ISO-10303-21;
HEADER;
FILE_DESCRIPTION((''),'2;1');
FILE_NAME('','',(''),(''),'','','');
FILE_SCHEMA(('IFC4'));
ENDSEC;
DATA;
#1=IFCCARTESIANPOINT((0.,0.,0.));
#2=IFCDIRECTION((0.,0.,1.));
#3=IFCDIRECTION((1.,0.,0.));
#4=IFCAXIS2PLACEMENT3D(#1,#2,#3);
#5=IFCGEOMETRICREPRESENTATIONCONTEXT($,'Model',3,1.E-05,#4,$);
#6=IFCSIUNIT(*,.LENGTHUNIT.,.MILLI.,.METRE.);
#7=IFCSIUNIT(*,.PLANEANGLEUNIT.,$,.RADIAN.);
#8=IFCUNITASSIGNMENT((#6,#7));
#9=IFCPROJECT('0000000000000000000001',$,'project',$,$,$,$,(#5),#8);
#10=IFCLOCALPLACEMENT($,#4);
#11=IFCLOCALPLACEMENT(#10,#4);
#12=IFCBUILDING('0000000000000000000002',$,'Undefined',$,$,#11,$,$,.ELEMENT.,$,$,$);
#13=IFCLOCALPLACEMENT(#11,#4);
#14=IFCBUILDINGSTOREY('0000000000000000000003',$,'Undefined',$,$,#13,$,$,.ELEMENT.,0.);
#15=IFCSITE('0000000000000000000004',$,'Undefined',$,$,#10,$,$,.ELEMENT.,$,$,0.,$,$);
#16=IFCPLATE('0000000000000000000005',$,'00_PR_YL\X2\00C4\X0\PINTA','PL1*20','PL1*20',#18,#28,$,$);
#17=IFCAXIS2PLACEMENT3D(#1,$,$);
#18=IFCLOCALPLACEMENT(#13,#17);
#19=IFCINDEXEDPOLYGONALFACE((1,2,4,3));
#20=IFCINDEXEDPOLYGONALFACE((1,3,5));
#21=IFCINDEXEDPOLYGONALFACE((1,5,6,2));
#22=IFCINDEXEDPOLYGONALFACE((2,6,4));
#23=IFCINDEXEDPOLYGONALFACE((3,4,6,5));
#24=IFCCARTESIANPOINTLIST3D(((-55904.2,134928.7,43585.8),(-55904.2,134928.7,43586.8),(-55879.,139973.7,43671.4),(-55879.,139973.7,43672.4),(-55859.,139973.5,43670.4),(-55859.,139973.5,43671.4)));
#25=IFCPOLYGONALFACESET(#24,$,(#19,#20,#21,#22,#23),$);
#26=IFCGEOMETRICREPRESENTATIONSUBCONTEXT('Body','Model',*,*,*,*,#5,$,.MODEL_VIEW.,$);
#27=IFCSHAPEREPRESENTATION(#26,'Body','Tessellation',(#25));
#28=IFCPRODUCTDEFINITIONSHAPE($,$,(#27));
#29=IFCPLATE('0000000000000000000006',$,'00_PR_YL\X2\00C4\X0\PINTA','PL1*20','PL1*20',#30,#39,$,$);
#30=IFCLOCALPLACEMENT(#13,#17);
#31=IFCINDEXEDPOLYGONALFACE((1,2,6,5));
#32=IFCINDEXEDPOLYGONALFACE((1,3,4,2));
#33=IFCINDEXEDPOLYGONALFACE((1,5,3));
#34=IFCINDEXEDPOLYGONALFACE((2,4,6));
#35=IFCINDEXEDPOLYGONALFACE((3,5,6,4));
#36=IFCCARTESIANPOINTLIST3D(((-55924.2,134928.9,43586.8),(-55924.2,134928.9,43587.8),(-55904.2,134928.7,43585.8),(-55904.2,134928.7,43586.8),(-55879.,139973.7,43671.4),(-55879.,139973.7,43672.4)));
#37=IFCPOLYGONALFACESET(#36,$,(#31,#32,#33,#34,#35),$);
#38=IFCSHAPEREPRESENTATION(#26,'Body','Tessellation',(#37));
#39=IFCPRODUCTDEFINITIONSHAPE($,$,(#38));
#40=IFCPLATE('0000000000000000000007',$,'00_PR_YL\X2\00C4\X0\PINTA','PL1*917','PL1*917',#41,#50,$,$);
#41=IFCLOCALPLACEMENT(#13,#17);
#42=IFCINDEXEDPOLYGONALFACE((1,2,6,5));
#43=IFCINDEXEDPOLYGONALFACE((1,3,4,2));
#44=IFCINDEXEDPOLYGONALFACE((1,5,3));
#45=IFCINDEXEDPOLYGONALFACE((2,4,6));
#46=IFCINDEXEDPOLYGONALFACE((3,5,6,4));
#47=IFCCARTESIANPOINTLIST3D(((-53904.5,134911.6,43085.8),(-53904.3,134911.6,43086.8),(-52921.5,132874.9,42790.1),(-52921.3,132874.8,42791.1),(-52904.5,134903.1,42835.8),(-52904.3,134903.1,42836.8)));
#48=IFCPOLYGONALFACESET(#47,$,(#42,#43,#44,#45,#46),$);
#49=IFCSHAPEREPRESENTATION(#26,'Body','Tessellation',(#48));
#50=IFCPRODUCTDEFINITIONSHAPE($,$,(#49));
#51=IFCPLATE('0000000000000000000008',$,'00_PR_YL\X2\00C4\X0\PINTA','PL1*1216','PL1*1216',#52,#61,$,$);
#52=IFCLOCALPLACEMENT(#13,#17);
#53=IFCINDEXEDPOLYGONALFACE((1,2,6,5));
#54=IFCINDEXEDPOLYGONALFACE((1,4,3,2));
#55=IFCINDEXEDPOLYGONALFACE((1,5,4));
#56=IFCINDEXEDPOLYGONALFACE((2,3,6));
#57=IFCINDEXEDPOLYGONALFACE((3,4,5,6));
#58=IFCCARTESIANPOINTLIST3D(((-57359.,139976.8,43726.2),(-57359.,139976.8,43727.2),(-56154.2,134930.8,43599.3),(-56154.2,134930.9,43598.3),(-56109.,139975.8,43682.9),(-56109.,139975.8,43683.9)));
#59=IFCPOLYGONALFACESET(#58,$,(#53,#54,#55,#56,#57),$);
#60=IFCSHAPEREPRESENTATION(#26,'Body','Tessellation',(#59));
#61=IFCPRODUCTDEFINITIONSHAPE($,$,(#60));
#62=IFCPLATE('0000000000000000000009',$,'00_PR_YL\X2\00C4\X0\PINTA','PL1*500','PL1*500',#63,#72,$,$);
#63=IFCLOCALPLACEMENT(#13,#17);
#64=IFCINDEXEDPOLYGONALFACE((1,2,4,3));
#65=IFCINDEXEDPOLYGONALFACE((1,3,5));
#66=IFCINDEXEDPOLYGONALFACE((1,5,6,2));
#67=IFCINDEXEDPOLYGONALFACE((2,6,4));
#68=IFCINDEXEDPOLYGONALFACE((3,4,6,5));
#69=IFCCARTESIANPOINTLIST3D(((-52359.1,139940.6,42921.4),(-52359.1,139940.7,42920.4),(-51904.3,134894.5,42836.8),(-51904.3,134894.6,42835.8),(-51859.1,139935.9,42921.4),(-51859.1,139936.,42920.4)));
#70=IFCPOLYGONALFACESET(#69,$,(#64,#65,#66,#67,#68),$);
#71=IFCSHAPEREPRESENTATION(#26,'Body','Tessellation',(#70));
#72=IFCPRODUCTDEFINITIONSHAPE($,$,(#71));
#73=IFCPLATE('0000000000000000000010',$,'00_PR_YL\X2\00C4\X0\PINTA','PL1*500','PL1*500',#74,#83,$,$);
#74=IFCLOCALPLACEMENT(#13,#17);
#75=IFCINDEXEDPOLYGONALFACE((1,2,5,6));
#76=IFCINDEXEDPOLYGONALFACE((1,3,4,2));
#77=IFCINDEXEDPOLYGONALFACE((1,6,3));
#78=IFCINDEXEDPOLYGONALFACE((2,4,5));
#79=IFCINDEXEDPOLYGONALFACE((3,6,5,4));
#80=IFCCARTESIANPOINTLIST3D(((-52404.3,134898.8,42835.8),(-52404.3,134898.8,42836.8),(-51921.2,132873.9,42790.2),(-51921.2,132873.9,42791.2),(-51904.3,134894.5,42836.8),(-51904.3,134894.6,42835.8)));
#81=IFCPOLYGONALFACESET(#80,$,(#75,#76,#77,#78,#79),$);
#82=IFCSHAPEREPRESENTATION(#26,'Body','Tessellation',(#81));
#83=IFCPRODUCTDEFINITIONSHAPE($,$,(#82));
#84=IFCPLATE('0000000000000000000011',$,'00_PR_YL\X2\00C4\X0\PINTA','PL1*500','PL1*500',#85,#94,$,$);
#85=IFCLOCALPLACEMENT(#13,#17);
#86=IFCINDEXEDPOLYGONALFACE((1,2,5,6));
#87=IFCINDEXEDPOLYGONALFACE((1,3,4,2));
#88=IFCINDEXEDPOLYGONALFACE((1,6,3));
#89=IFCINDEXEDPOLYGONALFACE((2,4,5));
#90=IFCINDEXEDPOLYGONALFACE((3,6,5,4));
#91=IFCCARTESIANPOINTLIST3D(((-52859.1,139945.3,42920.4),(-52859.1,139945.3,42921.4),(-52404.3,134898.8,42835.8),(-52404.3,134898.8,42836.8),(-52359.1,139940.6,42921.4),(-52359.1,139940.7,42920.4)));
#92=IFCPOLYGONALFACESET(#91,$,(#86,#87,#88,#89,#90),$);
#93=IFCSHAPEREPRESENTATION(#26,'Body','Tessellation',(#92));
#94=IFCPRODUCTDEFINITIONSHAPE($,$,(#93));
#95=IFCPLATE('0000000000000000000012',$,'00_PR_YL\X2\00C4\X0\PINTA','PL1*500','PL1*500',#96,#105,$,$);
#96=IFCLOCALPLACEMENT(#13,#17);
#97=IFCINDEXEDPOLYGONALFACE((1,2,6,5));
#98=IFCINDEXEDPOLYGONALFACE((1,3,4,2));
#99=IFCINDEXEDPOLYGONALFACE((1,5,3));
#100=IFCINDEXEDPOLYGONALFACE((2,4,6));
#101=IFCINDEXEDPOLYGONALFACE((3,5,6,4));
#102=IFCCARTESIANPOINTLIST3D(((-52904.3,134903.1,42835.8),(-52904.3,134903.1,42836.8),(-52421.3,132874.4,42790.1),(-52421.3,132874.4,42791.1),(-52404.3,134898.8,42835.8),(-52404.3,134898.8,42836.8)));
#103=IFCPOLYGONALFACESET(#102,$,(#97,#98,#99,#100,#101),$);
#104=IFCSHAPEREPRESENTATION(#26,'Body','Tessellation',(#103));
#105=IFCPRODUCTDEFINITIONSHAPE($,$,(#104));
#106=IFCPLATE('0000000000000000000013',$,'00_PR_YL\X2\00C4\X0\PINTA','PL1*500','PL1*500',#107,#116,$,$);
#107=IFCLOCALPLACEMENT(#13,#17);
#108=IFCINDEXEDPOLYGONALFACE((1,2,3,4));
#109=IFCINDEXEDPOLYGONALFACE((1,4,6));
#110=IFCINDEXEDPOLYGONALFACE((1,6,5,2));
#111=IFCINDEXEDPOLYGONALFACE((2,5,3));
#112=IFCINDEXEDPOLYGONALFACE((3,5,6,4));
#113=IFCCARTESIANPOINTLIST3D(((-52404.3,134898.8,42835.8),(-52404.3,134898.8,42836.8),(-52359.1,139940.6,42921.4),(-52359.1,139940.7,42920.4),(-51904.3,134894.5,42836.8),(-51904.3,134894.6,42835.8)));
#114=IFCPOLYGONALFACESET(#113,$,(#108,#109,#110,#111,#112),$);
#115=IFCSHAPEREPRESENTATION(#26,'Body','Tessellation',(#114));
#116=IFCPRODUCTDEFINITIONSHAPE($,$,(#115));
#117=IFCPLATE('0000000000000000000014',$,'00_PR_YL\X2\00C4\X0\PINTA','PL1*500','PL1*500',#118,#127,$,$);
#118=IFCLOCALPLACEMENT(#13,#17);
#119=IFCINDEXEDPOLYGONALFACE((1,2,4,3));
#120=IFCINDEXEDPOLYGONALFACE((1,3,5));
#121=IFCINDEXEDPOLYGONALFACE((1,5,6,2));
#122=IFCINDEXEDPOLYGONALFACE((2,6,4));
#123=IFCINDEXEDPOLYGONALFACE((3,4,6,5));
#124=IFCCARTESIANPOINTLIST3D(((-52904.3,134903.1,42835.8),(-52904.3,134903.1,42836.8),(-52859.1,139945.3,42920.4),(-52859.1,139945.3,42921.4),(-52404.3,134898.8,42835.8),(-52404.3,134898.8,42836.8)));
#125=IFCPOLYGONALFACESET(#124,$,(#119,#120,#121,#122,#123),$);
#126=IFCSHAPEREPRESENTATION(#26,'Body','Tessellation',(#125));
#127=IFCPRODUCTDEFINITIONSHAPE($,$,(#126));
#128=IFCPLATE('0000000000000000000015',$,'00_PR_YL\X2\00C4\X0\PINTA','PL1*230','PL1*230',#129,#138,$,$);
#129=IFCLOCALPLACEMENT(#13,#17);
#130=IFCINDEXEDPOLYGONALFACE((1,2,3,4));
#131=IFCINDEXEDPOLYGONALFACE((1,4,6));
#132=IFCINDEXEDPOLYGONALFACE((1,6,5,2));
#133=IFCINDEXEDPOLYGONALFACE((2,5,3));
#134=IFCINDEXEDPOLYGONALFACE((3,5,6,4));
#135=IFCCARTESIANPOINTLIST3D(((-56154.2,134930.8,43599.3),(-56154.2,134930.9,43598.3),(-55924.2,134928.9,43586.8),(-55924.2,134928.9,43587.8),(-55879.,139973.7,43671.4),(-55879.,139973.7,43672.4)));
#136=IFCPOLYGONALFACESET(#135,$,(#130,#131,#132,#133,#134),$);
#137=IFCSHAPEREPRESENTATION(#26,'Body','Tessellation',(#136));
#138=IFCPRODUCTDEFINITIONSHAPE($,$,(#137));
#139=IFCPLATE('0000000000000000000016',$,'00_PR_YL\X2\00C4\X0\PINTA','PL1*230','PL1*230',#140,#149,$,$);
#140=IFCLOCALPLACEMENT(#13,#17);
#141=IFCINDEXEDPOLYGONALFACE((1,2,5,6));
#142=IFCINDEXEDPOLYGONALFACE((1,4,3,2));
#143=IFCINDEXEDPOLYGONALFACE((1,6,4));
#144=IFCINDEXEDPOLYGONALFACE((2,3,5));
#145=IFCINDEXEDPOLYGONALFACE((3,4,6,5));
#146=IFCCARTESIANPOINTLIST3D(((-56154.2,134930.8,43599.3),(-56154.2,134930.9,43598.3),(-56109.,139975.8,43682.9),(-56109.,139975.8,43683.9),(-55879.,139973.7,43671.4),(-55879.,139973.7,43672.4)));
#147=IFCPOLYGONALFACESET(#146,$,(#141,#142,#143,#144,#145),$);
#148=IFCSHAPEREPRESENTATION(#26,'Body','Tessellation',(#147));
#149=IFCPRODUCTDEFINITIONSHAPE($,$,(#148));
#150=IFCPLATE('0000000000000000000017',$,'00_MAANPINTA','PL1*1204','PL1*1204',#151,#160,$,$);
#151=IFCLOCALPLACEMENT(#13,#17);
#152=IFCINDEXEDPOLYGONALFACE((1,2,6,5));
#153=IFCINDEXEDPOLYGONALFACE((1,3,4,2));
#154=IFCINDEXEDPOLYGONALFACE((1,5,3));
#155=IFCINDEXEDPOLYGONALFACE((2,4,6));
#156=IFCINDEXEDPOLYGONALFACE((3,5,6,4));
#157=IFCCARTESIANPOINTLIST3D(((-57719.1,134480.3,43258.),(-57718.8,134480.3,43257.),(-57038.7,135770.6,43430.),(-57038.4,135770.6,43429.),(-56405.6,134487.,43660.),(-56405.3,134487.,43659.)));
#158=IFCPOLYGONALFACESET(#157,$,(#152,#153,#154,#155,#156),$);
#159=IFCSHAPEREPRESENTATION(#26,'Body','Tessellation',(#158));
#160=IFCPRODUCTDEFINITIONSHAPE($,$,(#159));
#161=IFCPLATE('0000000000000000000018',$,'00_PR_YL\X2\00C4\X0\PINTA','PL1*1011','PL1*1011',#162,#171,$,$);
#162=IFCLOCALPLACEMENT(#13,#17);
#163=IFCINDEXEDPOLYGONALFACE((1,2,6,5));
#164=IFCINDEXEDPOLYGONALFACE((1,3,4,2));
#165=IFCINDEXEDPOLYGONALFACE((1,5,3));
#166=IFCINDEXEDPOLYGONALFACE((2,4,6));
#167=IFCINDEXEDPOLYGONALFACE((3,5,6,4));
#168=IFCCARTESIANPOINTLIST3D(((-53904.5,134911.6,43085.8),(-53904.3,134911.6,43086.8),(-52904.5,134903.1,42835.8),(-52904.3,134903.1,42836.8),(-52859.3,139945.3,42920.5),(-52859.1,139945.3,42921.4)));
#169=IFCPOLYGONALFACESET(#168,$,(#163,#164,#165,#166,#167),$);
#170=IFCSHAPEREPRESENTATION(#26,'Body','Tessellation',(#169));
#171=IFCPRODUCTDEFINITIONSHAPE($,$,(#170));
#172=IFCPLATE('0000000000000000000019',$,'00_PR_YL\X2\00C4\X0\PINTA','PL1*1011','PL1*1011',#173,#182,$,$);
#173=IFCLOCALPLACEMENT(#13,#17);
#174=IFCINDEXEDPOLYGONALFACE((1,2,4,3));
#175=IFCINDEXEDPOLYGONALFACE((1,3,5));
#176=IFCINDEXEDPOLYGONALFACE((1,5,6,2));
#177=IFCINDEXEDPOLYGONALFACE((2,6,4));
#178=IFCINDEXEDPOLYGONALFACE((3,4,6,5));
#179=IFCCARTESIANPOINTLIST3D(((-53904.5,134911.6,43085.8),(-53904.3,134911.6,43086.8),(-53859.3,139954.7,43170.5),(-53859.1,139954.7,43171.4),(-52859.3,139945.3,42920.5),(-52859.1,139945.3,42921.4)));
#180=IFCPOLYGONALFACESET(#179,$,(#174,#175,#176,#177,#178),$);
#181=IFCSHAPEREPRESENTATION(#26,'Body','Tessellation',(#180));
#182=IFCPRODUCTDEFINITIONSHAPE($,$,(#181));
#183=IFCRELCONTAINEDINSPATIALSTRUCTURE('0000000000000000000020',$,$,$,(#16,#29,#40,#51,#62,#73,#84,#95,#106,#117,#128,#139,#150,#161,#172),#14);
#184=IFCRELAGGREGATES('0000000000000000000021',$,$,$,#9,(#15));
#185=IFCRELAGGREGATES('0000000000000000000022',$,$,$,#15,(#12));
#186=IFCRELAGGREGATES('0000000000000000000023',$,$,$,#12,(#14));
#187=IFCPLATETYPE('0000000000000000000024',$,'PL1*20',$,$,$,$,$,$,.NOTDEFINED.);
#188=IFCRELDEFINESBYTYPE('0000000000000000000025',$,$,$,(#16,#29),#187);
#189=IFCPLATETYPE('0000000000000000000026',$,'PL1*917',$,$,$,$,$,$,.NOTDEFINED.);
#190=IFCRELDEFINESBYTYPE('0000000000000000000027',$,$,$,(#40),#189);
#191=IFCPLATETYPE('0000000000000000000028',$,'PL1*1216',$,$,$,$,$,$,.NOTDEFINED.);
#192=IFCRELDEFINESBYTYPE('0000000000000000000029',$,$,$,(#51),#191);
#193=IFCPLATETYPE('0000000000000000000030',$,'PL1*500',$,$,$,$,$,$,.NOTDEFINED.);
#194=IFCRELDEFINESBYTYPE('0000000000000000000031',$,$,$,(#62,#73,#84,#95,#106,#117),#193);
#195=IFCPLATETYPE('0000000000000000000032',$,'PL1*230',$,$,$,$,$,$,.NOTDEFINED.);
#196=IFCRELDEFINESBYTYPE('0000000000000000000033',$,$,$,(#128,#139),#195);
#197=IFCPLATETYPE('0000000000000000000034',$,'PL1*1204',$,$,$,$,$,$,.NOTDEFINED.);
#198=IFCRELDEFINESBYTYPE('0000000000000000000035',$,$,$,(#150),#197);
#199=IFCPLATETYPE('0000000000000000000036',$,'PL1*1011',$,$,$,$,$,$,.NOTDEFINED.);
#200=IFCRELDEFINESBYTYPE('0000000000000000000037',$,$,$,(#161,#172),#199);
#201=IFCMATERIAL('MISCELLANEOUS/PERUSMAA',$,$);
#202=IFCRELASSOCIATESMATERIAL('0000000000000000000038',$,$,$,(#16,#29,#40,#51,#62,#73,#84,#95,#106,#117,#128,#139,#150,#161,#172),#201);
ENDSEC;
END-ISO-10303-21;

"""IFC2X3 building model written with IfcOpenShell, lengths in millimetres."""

from ifc_helpers import new_model, si_unit, frame, origin_with_axes, place, context, subcontext, project, spatial, polyline, outline, extrude, material, type_object, element, save


model = new_model("IFC2X3")

# Units and contexts
model_context = context("Model", 3, precision=1e-05, world=origin_with_axes())
body_context = subcontext(model_context, "Body", "Model", "MODEL_VIEW")
ifc_project = project(units=[si_unit("LENGTHUNIT", "METRE", prefix="MILLI"), si_unit("PLANEANGLEUNIT", "RADIAN")], contexts=[model_context])

# Site, building, storey
site_placement = place(None, origin_with_axes())
site = spatial("IfcSite", under=ifc_project, at=site_placement, Name="Undefined", CompositionType="ELEMENT", RefElevation=0.0)
building_placement = place(site_placement, origin_with_axes())
building = spatial("IfcBuilding", under=site, at=building_placement, Name="Undefined", CompositionType="ELEMENT")
storey_placement = place(building_placement, origin_with_axes())
storey = spatial("IfcBuildingStorey", under=building, at=storey_placement, Name="Undefined", CompositionType="ELEMENT", Elevation=0.0)

# Plates
ifc_material = material(Name="MISCELLANEOUS/PERUSMAA")
plate_type_1 = type_object("IfcPlateType", Name="PL1*20", PredefinedType="NOTDEFINED")
plate_1_placement = place(storey_placement, frame((-55904.2, 134928.7, 43586.3), z_axis=(-0.049773, 0.017208, -0.998612), x_axis=(0.004996, 0.999843, 0.01698)))
element("IfcPlate", 1, at=plate_1_placement, inside=storey, type_object=plate_type_1, material=ifc_material, Name="00_PR_YLÄPINTA", Description="PL1*20", ObjectType="PL1*20", context=body_context, shape_type="SweptSolid", body=[
    extrude(outline(polyline([(0.0, 0.0), (5045.8, 0.0), (5045.6, 20.0), (0.0, 0.0)])), frame((0.0, 0.0, -0.5), z_axis=(0.0, 0.0, 1.0), x_axis=(1.0, 0.0, 0.0)), (0.0, 0.0, 1.0), 1.0),
])
plate_2_placement = place(storey_placement, frame((-55924.2, 134928.9, 43587.3), z_axis=(-0.049785, 0.017208, -0.998612), x_axis=(0.00896, 0.999819, 0.016782)))
element("IfcPlate", 2, at=plate_2_placement, inside=storey, type_object=plate_type_1, material=ifc_material, Name="00_PR_YLÄPINTA", Description="PL1*20", ObjectType="PL1*20", context=body_context, shape_type="SweptSolid", body=[
    extrude(outline(polyline([(0.0, 0.0), (5045.7, 0.0), (0.0, 20.0), (0.0, 0.0)])), frame((0.0, 0.0, -0.5), z_axis=(0.0, 0.0, 1.0), x_axis=(1.0, 0.0, 0.0)), (0.0, 0.0, 1.0), 1.0),
])
plate_type_2 = type_object("IfcPlateType", Name="PL1*917", PredefinedType="NOTDEFINED")
plate_3_placement = place(storey_placement, frame((-52904.4, 134903.1, 42836.3), z_axis=(-0.242283, 0.023882, -0.969912), x_axis=(-0.008367, -0.999711, -0.022526)))
element("IfcPlate", 3, at=plate_3_placement, inside=storey, type_object=plate_type_2, material=ifc_material, Name="00_PR_YLÄPINTA", Description="PL1*917", ObjectType="PL1*917", context=body_context, shape_type="SweptSolid", body=[
    extrude(outline(polyline([(0.0, 0.0), (2028.8, 0.0), (-5.8, 1030.8), (0.0, 0.0)])), frame((0.0, 0.0, -0.5), z_axis=(0.0, 0.0, 1.0), x_axis=(1.0, 0.0, 0.0)), (0.0, 0.0, 1.0), 1.0),
])
plate_type_3 = type_object("IfcPlateType", Name="PL1*1216", PredefinedType="NOTDEFINED")
plate_4_placement = place(storey_placement, frame((-56109.0, 139975.8, 43683.4), z_axis=(-0.034582, 0.017082, -0.999256), x_axis=(-0.00896, -0.999819, -0.016782)))
element("IfcPlate", 4, at=plate_4_placement, inside=storey, type_object=plate_type_3, material=ifc_material, Name="00_PR_YLÄPINTA", Description="PL1*1216", ObjectType="PL1*1216", context=body_context, shape_type="SweptSolid", body=[
    extrude(outline(polyline([(0.0, 0.0), (5045.9, 0.0), (9.5, 1250.8), (0.0, 0.0)])), frame((0.0, 0.0, -0.5), z_axis=(0.0, 0.0, 1.0), x_axis=(1.0, 0.0, 0.0)), (0.0, 0.0, 1.0), 1.0),
])
plate_type_4 = type_object("IfcPlateType", Name="PL1*500", PredefinedType="NOTDEFINED")
plate_5_placement = place(storey_placement, frame((-51859.1, 139936.0, 42920.9), z_axis=(0.000158, 0.016793, -0.999859), x_axis=(-0.00896, -0.999819, -0.016793)))
element("IfcPlate", 5, at=plate_5_placement, inside=storey, type_object=plate_type_4, material=ifc_material, Name="00_PR_YLÄPINTA", Description="PL1*500", ObjectType="PL1*500", context=body_context, shape_type="SweptSolid", body=[
    extrude(outline(polyline([(0.0, 0.0), (5042.3, 0.0), (-0.2, 500.0), (0.0, 0.0)])), frame((0.0, 0.0, -0.5), z_axis=(0.0, 0.0, 1.0), x_axis=(1.0, 0.0, 0.0)), (0.0, 0.0, 1.0), 1.0),
])
plate_6_placement = place(storey_placement, frame((-51904.3, 134894.6, 42836.3), z_axis=(0.000192, 0.022529, -0.999746), x_axis=(-0.008368, -0.999711, -0.02253)))
element("IfcPlate", 6, at=plate_6_placement, inside=storey, type_object=plate_type_4, material=ifc_material, Name="00_PR_YLÄPINTA", Description="PL1*500", ObjectType="PL1*500", context=body_context, shape_type="SweptSolid", body=[
    extrude(outline(polyline([(0.0, 0.0), (2021.2, 0.0), (-0.1, 500.0), (0.0, 0.0)])), frame((0.0, 0.0, -0.5), z_axis=(0.0, 0.0, 1.0), x_axis=(1.0, 0.0, 0.0)), (0.0, 0.0, 1.0), 1.0),
])
plate_7_placement = place(storey_placement, frame((-52359.1, 139940.6, 42920.9), z_axis=(0.000158, 0.016791, -0.999859), x_axis=(-0.00896, -0.999819, -0.016792)))
element("IfcPlate", 7, at=plate_7_placement, inside=storey, type_object=plate_type_4, material=ifc_material, Name="00_PR_YLÄPINTA", Description="PL1*500", ObjectType="PL1*500", context=body_context, shape_type="SweptSolid", body=[
    extrude(outline(polyline([(0.0, 0.0), (5042.7, 0.0), (-0.2, 500.0), (0.0, 0.0)])), frame((0.0, 0.0, -0.5), z_axis=(0.0, 0.0, 1.0), x_axis=(1.0, 0.0, 0.0)), (0.0, 0.0, 1.0), 1.0),
])
plate_8_placement = place(storey_placement, frame((-52404.3, 134898.8, 42836.3), z_axis=(0.000192, 0.022527, -0.999746), x_axis=(-0.008368, -0.999711, -0.022528)))
element("IfcPlate", 8, at=plate_8_placement, inside=storey, type_object=plate_type_4, material=ifc_material, Name="00_PR_YLÄPINTA", Description="PL1*500", ObjectType="PL1*500", context=body_context, shape_type="SweptSolid", body=[
    extrude(outline(polyline([(0.0, 0.0), (2025.0, 0.0), (-0.1, 500.0), (0.0, 0.0)])), frame((0.0, 0.0, -0.5), z_axis=(0.0, 0.0, 1.0), x_axis=(1.0, 0.0, 0.0)), (0.0, 0.0, 1.0), 1.0),
])
plate_9_placement = place(storey_placement, frame((-52404.3, 134898.8, 42836.3), z_axis=(0.000143, 0.016791, -0.999859), x_axis=(0.00896, 0.999819, 0.016792)))
element("IfcPlate", 9, at=plate_9_placement, inside=storey, type_object=plate_type_4, material=ifc_material, Name="00_PR_YLÄPINTA", Description="PL1*500", ObjectType="PL1*500", context=body_context, shape_type="SweptSolid", body=[
    extrude(outline(polyline([(0.0, 0.0), (5042.7, 0.0), (0.2, 500.0), (0.0, 0.0)])), frame((0.0, 0.0, -0.5), z_axis=(0.0, 0.0, 1.0), x_axis=(1.0, 0.0, 0.0)), (0.0, 0.0, 1.0), 1.0),
])
plate_10_placement = place(storey_placement, frame((-52904.3, 134903.1, 42836.3), z_axis=(0.000143, 0.01679, -0.999859), x_axis=(0.00896, 0.999819, 0.01679)))
element("IfcPlate", 10, at=plate_10_placement, inside=storey, type_object=plate_type_4, material=ifc_material, Name="00_PR_YLÄPINTA", Description="PL1*500", ObjectType="PL1*500", context=body_context, shape_type="SweptSolid", body=[
    extrude(outline(polyline([(0.0, 0.0), (5043.2, 0.0), (0.2, 500.0), (0.0, 0.0)])), frame((0.0, 0.0, -0.5), z_axis=(0.0, 0.0, 1.0), x_axis=(1.0, 0.0, 0.0)), (0.0, 0.0, 1.0), 1.0),
])
plate_type_5 = type_object("IfcPlateType", Name="PL1*230", PredefinedType="NOTDEFINED")
plate_11_placement = place(storey_placement, frame((-55879.0, 139973.7, 43671.9), z_axis=(-0.049785, 0.017208, -0.998612), x_axis=(-0.00896, -0.999819, -0.016782)))
element("IfcPlate", 11, at=plate_11_placement, inside=storey, type_object=plate_type_5, material=ifc_material, Name="00_PR_YLÄPINTA", Description="PL1*230", ObjectType="PL1*230", context=body_context, shape_type="SweptSolid", body=[
    extrude(outline(polyline([(0.0, 0.0), (5045.7, 0.0), (5045.6, 230.3), (0.0, 0.0)])), frame((0.0, 0.0, -0.5), z_axis=(0.0, 0.0, 1.0), x_axis=(1.0, 0.0, 0.0)), (0.0, 0.0, 1.0), 1.0),
])
plate_12_placement = place(storey_placement, frame((-56154.2, 134930.8, 43598.8), z_axis=(-0.049771, 0.017207, -0.998612), x_axis=(0.00896, 0.999819, 0.016782)))
element("IfcPlate", 12, at=plate_12_placement, inside=storey, type_object=plate_type_5, material=ifc_material, Name="00_PR_YLÄPINTA", Description="PL1*230", ObjectType="PL1*230", context=body_context, shape_type="SweptSolid", body=[
    extrude(outline(polyline([(0.0, 0.0), (5045.9, 0.0), (5045.6, 230.3), (0.0, 0.0)])), frame((0.0, 0.0, -0.5), z_axis=(0.0, 0.0, 1.0), x_axis=(1.0, 0.0, 0.0)), (0.0, 0.0, 1.0), 1.0),
])
plate_type_6 = type_object("IfcPlateType", Name="PL1*1204", PredefinedType="NOTDEFINED")
plate_13_placement = place(storey_placement, frame((-56405.4, 134487.0, 43659.5), z_axis=(0.292679, -0.026916, -0.955832), x_axis=(-0.956205, -0.004849, -0.292656)))
element("IfcPlate", 13, at=plate_13_placement, inside=storey, type_object=plate_type_6, material=ifc_material, Name="00_MAANPINTA", Description="PL1*1204", ObjectType="PL1*1204", context=body_context, shape_type="SweptSolid", body=[
    extrude(outline(polyline([(0.0, 0.0), (1373.6, 0.0), (666.4, 1287.3), (0.0, 0.0)])), frame((0.0, 0.0, -0.5), z_axis=(0.0, 0.0, 1.0), x_axis=(1.0, 0.0, 0.0)), (0.0, 0.0, 1.0), 1.0),
])
plate_type_7 = type_object("IfcPlateType", Name="PL1*1011", PredefinedType="NOTDEFINED")
plate_14_placement = place(storey_placement, frame((-52859.2, 139945.3, 42921.0), z_axis=(-0.242354, 0.018462, -0.970012), x_axis=(-0.00896, -0.999819, -0.01679)))
element("IfcPlate", 14, at=plate_14_placement, inside=storey, type_object=plate_type_7, material=ifc_material, Name="00_PR_YLÄPINTA", Description="PL1*1011", ObjectType="PL1*1011", context=body_context, shape_type="SweptSolid", body=[
    extrude(outline(polyline([(0.0, 0.0), (5043.2, 0.0), (5039.4, 1030.8), (0.0, 0.0)])), frame((0.0, 0.0, -0.5), z_axis=(0.0, 0.0, 1.0), x_axis=(1.0, 0.0, 0.0)), (0.0, 0.0, 1.0), 1.0),
])
plate_15_placement = place(storey_placement, frame((-53904.4, 134911.6, 43086.3), z_axis=(-0.242341, 0.018459, -0.970015), x_axis=(0.00896, 0.999819, 0.016788)))
element("IfcPlate", 15, at=plate_15_placement, inside=storey, type_object=plate_type_7, material=ifc_material, Name="00_PR_YLÄPINTA", Description="PL1*1011", ObjectType="PL1*1011", context=body_context, shape_type="SweptSolid", body=[
    extrude(outline(polyline([(0.0, 0.0), (5044.0, 0.0), (5039.4, 1030.8), (0.0, 0.0)])), frame((0.0, 0.0, -0.5), z_axis=(0.0, 0.0, 1.0), x_axis=(1.0, 0.0, 0.0)), (0.0, 0.0, 1.0), 1.0),
])

save(model, "model.ifc")
